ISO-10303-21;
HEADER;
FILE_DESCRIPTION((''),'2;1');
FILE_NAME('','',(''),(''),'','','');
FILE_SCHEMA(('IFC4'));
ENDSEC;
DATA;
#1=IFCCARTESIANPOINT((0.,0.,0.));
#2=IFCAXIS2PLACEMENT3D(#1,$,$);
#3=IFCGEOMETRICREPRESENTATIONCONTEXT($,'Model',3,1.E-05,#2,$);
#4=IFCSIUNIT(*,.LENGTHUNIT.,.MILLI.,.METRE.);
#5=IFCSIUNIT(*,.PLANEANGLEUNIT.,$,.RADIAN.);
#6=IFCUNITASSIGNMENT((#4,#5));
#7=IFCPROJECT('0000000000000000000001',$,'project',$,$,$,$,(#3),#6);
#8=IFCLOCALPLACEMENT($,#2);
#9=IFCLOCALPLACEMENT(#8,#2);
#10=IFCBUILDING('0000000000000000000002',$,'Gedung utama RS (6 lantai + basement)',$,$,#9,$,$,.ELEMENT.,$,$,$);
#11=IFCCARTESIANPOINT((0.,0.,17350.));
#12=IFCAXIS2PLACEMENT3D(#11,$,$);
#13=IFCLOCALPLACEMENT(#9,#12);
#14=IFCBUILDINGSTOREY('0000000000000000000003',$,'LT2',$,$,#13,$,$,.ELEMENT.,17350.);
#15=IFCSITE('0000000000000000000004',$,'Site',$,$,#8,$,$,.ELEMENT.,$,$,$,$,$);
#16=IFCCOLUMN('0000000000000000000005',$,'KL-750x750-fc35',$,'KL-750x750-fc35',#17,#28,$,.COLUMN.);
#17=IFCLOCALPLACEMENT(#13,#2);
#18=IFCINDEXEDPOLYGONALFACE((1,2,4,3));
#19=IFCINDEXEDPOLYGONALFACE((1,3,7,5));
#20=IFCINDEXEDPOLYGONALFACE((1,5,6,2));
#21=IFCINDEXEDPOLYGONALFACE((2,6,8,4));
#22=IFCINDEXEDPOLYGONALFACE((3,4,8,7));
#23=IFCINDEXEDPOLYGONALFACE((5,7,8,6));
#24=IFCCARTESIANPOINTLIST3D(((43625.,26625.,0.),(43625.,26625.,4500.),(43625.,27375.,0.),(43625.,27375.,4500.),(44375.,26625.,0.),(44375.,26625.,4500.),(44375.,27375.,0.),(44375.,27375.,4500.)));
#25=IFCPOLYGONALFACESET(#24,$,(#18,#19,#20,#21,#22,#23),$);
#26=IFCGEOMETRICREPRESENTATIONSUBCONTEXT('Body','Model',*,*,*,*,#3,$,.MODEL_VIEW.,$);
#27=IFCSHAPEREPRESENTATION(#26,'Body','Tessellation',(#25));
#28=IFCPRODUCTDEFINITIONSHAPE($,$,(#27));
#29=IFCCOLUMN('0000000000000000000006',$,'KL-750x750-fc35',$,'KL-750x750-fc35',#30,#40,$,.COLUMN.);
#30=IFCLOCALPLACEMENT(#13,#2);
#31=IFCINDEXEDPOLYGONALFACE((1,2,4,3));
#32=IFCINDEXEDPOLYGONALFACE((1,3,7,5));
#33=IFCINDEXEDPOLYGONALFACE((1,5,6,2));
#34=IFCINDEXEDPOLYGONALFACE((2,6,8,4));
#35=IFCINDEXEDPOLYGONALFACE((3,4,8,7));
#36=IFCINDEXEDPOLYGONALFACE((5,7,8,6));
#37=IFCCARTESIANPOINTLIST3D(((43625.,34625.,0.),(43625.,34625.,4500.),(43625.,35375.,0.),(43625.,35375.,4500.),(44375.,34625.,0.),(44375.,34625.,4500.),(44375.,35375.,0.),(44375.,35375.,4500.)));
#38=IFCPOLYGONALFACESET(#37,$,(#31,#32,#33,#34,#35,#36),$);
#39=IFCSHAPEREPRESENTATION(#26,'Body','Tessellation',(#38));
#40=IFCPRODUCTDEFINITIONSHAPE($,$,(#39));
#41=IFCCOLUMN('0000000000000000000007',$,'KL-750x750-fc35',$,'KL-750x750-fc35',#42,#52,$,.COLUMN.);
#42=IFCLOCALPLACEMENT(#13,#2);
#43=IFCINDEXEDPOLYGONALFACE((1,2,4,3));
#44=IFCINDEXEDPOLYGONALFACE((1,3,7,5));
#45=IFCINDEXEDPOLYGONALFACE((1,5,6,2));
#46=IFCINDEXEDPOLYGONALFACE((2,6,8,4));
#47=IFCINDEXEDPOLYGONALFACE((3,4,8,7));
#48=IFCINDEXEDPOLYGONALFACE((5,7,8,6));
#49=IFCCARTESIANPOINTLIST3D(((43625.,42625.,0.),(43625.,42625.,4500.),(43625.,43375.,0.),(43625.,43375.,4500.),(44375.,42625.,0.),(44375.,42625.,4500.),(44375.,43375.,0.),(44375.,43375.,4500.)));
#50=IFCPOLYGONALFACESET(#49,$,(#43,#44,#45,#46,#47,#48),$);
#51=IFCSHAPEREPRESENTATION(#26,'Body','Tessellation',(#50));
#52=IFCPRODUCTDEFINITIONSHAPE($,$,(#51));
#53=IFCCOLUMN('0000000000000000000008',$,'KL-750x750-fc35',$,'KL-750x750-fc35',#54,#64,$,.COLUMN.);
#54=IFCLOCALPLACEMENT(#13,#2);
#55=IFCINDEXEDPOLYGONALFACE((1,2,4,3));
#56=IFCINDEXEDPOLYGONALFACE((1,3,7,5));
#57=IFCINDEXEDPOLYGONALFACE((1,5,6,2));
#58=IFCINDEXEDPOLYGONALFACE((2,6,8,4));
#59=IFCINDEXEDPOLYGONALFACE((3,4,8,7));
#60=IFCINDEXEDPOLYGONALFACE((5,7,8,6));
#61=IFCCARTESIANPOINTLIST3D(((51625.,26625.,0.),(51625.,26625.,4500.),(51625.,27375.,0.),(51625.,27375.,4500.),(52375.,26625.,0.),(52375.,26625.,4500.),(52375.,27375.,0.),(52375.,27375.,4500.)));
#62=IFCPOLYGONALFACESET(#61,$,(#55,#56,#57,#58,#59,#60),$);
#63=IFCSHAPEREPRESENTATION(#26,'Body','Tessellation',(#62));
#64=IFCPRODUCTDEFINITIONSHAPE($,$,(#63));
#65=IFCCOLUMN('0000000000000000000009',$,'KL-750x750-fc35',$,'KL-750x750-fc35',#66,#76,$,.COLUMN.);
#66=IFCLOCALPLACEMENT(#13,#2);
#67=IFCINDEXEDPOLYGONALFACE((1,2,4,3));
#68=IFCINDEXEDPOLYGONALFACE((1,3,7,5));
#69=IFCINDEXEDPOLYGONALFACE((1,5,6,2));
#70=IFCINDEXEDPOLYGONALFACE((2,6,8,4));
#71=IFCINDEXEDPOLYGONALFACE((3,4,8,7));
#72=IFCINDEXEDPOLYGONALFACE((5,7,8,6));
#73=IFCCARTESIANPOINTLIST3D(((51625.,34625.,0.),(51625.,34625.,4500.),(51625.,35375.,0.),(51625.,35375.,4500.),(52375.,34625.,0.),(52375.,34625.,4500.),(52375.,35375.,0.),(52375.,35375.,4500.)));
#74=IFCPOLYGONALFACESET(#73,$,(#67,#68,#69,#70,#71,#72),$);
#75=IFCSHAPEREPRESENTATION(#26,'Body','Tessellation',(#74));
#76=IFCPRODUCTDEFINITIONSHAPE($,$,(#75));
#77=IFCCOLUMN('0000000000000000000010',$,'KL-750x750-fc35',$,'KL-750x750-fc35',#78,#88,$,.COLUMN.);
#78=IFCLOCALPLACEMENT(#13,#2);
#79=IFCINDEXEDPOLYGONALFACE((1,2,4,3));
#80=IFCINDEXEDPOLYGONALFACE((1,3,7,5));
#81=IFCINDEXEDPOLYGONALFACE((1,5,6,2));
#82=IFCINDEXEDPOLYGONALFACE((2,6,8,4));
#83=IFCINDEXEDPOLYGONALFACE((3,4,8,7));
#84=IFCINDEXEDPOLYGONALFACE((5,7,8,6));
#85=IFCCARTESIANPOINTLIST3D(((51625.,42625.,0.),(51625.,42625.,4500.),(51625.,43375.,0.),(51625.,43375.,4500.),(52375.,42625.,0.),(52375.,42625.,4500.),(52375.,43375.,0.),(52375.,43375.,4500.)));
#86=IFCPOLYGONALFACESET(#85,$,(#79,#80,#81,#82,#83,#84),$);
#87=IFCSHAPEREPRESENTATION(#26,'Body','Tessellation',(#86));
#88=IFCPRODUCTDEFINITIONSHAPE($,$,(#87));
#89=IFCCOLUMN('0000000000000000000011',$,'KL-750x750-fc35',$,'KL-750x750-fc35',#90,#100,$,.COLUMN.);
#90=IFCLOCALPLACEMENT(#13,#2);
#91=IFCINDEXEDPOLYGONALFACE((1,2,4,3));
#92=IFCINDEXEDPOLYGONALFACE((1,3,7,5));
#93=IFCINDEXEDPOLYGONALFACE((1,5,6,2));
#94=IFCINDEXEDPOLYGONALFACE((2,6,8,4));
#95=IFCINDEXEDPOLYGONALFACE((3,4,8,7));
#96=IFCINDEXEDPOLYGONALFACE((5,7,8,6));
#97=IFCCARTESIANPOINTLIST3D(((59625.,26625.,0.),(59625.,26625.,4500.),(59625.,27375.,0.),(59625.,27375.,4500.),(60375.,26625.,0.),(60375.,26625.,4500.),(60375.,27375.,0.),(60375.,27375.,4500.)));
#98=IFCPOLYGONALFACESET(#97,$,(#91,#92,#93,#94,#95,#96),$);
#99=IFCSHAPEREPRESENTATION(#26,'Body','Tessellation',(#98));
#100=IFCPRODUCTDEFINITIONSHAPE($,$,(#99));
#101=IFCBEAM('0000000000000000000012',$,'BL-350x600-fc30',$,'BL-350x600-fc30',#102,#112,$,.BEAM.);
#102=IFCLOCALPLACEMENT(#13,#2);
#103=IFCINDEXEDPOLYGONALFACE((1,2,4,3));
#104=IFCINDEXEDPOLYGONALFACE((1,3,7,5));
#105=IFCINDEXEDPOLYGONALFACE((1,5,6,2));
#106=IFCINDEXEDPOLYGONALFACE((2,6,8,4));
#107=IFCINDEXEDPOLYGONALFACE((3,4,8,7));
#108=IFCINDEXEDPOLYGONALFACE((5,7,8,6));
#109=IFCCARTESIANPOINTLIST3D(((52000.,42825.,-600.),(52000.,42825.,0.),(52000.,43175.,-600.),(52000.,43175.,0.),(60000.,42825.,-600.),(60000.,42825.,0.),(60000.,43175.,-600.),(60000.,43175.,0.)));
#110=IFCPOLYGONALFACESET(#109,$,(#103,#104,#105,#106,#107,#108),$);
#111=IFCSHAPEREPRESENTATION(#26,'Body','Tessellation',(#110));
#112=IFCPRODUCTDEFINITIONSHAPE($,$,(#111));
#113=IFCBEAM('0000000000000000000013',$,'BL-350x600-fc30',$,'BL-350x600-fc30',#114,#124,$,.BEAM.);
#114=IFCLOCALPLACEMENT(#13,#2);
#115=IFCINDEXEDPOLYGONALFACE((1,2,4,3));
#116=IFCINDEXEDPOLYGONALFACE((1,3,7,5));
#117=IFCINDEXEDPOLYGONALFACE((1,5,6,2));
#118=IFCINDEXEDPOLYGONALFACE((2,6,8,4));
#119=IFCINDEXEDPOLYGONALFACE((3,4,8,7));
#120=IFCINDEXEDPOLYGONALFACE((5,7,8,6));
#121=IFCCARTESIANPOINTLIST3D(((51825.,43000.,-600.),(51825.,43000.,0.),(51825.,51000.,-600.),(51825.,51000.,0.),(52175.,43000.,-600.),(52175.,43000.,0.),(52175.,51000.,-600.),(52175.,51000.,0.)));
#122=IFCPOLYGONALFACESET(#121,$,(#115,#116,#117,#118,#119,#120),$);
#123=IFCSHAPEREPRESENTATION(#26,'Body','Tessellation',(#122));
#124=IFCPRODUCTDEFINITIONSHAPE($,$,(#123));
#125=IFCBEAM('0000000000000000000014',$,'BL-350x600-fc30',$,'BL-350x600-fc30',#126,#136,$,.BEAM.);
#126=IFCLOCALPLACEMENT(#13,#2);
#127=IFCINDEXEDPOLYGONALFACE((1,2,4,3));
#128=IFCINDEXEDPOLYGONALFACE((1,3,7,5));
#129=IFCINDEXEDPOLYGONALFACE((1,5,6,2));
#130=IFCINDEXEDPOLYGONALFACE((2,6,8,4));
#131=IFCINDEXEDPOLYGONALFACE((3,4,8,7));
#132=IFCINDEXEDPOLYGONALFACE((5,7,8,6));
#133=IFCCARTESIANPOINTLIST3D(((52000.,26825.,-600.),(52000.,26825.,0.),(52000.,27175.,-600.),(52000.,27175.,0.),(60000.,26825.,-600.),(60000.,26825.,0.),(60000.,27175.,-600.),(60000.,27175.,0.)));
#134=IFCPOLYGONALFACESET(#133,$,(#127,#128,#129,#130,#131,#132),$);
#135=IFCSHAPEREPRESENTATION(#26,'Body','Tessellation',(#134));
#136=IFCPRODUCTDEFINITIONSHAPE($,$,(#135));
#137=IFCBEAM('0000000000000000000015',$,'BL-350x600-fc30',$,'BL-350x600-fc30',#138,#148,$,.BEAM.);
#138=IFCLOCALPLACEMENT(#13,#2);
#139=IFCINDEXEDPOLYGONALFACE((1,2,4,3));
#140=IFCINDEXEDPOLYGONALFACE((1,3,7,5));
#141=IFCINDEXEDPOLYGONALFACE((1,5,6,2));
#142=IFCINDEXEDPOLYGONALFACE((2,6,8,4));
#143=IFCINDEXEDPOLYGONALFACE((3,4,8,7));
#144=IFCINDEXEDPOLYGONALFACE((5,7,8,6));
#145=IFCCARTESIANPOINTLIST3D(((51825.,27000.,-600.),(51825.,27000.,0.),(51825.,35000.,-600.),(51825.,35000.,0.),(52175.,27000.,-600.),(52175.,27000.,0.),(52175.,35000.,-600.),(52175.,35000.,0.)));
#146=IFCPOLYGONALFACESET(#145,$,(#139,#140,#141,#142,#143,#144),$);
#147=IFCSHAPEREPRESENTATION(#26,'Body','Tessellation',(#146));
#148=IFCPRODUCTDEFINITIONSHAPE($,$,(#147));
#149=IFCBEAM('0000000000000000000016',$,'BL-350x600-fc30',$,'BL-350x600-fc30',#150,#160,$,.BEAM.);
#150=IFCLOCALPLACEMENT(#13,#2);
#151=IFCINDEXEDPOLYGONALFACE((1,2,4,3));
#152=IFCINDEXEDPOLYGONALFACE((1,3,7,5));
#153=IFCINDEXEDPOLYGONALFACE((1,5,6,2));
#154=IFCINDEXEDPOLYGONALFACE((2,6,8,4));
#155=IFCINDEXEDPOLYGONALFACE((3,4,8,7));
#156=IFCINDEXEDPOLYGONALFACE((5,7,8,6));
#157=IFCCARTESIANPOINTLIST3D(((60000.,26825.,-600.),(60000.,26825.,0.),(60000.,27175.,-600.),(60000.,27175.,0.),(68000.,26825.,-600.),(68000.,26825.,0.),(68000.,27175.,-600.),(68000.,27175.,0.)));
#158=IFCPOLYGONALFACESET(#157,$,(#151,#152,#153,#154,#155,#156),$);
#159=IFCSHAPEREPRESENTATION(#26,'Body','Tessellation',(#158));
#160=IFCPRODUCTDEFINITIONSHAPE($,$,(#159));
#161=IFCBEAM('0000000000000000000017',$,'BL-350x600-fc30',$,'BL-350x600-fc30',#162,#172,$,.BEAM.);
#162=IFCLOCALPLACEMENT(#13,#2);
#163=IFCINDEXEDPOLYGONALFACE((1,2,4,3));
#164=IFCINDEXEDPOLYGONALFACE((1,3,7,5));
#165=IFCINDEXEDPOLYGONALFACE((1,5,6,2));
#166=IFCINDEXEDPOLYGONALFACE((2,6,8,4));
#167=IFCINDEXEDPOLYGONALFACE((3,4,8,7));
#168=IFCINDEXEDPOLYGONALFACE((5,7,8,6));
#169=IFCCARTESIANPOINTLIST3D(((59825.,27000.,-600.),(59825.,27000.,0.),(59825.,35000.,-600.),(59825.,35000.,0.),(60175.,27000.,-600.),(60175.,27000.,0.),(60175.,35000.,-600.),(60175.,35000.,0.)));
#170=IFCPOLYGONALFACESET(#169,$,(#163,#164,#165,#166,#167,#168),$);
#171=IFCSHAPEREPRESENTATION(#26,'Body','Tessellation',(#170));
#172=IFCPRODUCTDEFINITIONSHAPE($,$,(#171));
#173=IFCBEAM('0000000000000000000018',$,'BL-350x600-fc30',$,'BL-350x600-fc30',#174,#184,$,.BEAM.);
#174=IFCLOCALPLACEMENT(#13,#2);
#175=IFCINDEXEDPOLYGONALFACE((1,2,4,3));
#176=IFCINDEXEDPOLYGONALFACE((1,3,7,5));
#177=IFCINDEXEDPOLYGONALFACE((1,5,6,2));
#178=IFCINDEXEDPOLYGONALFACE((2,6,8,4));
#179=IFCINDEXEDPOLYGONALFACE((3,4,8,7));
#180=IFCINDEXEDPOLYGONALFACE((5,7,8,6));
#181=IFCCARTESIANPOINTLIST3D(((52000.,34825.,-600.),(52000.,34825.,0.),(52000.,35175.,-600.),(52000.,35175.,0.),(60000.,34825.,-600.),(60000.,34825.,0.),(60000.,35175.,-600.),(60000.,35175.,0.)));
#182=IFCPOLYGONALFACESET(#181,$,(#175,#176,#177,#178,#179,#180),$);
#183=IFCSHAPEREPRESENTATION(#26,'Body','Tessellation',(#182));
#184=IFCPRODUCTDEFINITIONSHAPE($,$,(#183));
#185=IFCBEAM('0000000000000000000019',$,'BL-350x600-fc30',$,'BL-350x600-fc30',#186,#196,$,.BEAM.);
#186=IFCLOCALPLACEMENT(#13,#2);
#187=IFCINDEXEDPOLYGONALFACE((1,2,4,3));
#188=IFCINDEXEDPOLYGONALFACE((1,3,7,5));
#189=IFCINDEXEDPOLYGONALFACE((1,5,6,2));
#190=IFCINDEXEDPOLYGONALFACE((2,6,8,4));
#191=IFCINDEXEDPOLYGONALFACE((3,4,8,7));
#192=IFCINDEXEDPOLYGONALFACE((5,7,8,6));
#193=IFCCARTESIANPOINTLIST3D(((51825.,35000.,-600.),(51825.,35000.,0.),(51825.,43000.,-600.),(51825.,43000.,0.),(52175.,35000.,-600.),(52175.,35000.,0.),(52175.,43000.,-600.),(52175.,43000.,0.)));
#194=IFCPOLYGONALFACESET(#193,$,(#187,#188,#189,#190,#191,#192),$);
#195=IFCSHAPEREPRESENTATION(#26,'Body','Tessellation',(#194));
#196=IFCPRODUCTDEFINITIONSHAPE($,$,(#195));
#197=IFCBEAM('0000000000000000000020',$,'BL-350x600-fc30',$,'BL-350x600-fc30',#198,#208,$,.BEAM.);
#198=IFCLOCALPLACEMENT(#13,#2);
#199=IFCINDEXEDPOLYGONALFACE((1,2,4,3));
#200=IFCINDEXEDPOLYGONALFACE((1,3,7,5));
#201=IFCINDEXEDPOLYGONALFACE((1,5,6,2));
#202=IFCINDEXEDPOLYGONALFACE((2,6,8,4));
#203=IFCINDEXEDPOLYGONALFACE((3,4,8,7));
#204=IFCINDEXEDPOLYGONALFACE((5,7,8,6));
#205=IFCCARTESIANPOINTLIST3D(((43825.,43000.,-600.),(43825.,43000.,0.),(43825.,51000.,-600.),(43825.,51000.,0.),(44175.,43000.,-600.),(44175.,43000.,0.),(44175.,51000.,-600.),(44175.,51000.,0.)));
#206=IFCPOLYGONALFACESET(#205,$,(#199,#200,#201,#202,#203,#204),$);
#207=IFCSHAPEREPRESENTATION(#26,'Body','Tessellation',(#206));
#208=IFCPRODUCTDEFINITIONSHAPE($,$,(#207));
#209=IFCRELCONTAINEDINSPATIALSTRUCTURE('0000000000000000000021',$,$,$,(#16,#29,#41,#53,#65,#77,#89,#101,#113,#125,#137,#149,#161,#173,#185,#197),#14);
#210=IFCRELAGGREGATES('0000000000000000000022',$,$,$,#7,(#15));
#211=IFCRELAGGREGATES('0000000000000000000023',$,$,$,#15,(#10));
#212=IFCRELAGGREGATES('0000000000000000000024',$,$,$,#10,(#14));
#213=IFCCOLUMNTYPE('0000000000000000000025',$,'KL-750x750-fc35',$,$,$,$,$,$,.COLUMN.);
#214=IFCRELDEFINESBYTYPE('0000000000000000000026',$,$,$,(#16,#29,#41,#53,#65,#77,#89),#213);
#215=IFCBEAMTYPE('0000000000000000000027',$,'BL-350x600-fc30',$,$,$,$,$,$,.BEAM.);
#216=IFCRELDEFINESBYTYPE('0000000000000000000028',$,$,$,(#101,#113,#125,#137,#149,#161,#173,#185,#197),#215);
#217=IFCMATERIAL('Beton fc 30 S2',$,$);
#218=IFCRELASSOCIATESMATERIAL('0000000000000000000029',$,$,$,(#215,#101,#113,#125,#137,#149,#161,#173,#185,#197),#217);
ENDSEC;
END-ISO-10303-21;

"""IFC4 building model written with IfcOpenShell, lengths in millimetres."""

from ifc_helpers import new_model, si_unit, frame, origin, origin_2d, place, context, subcontext, project, spatial, rectangle, extrude, material, material_profile, profile_set, profile_usage, type_object, element, save


model = new_model("IFC4")

# Units and contexts
model_context = context("Model", 3, precision=1e-05, world=origin())
body_context = subcontext(model_context, "Body", "Model", "MODEL_VIEW")
ifc_project = project(units=[si_unit("LENGTHUNIT", "METRE", prefix="MILLI"), si_unit("PLANEANGLEUNIT", "RADIAN")], contexts=[model_context])

# Site, building, storey
site_placement = place(None, origin())
site = spatial("IfcSite", under=ifc_project, at=site_placement, Name="Site", CompositionType="ELEMENT")
building_placement = place(site_placement, origin())
building = spatial("IfcBuilding", under=site, at=building_placement, Name="Gedung utama RS (6 lantai + basement)", CompositionType="ELEMENT")
storey_placement = place(building_placement, frame((0.0, 0.0, 17350.0)))
storey = spatial("IfcBuildingStorey", under=building, at=storey_placement, Name="LT2", CompositionType="ELEMENT", Elevation=17350.0)

# Columns
ifc_material_profile_1 = material_profile(None, rectangle(XDim=750.0, YDim=750.0, at=origin_2d()), Name="KL-750x750-fc35")
ifc_profile_set_1 = profile_set([ifc_material_profile_1], Name="KL-750x750-fc35")
ifc_profile_usage_1 = profile_usage(ifc_profile_set_1, cardinal=5)
column_type = type_object("IfcColumnType", Name="KL-750x750-fc35", PredefinedType="COLUMN", material=ifc_profile_set_1)
for number, where, z_axis, x_axis, name in (
    (1, (44000.0, 27000.0, 0.0), (0.0, 0.0, 1.0), (1.0, 0.0, 0.0), "KL-750x750-fc35"),
    (2, (44000.0, 35000.0, 0.0), (0.0, 0.0, 1.0), (1.0, 0.0, 0.0), "KL-750x750-fc35"),
    (3, (44000.0, 43000.0, 0.0), (0.0, 0.0, 1.0), (1.0, 0.0, 0.0), "KL-750x750-fc35"),
    (4, (52000.0, 27000.0, 0.0), (0.0, 0.0, 1.0), (1.0, 0.0, 0.0), "KL-750x750-fc35"),
    (5, (52000.0, 35000.0, 0.0), (0.0, 0.0, 1.0), (1.0, 0.0, 0.0), "KL-750x750-fc35"),
    (6, (52000.0, 43000.0, 0.0), (0.0, 0.0, 1.0), (1.0, 0.0, 0.0), "KL-750x750-fc35"),
    (7, (60000.0, 27000.0, 0.0), (0.0, 0.0, 1.0), (1.0, 0.0, 0.0), "KL-750x750-fc35"),
):
    element("IfcColumn", number, at=place(storey_placement, frame(where, z_axis=z_axis, x_axis=x_axis)), inside=storey, type_object=column_type, material=ifc_profile_usage_1, Name=name, ObjectType="KL-750x750-fc35", PredefinedType="COLUMN", context=body_context, shape_type="SweptSolid", body=[
        extrude(rectangle(XDim=750.0, YDim=750.0, at=origin_2d()), origin(), (0.0, 0.0, 1.0), 4500.0),
    ])

# Beams
ifc_material_1 = material(Name="Beton fc 30 S2")
ifc_material_profile_2 = material_profile(ifc_material_1, rectangle(XDim=350.0, YDim=600.0, at=origin_2d()), Name="BL-350x600-fc30")
ifc_profile_set_2 = profile_set([ifc_material_profile_2], Name="BL-350x600-fc30")
ifc_profile_usage_2 = profile_usage(ifc_profile_set_2, cardinal=8)
beam_type = type_object("IfcBeamType", Name="BL-350x600-fc30", PredefinedType="BEAM", material=ifc_profile_set_2)
beam_1_placement = place(storey_placement, frame((52000.0, 43000.0, -300.0)))
element("IfcBeam", 8, at=beam_1_placement, inside=storey, type_object=beam_type, material=ifc_profile_usage_2, Name="BL-350x600-fc30", ObjectType="BL-350x600-fc30", PredefinedType="BEAM", context=body_context, shape_type="SweptSolid", body=[
    extrude(rectangle(XDim=350.0, YDim=600.0, at=origin_2d()), frame((0.0, 0.0, 0.0), z_axis=(1.0, 0.0, 0.0), x_axis=(0.0, 1.0, 0.0)), (0.0, 0.0, 1.0), 8000.0),
])
beam_2_placement = place(storey_placement, frame((52000.0, 43000.0, -300.0)))
element("IfcBeam", 9, at=beam_2_placement, inside=storey, type_object=beam_type, material=ifc_profile_usage_2, Name="BL-350x600-fc30", ObjectType="BL-350x600-fc30", PredefinedType="BEAM", context=body_context, shape_type="SweptSolid", body=[
    extrude(rectangle(XDim=350.0, YDim=600.0, at=origin_2d()), frame((0.0, 0.0, 0.0), z_axis=(0.0, 1.0, 0.0), x_axis=(-1.0, 0.0, 0.0)), (0.0, 0.0, 1.0), 8000.0),
])
beam_3_placement = place(storey_placement, frame((52000.0, 27000.0, -300.0)))
element("IfcBeam", 10, at=beam_3_placement, inside=storey, type_object=beam_type, material=ifc_profile_usage_2, Name="BL-350x600-fc30", ObjectType="BL-350x600-fc30", PredefinedType="BEAM", context=body_context, shape_type="SweptSolid", body=[
    extrude(rectangle(XDim=350.0, YDim=600.0, at=origin_2d()), frame((0.0, 0.0, 0.0), z_axis=(1.0, 0.0, 0.0), x_axis=(0.0, 1.0, 0.0)), (0.0, 0.0, 1.0), 8000.0),
])
beam_4_placement = place(storey_placement, frame((52000.0, 27000.0, -300.0)))
element("IfcBeam", 11, at=beam_4_placement, inside=storey, type_object=beam_type, material=ifc_profile_usage_2, Name="BL-350x600-fc30", ObjectType="BL-350x600-fc30", PredefinedType="BEAM", context=body_context, shape_type="SweptSolid", body=[
    extrude(rectangle(XDim=350.0, YDim=600.0, at=origin_2d()), frame((0.0, 0.0, 0.0), z_axis=(0.0, 1.0, 0.0), x_axis=(-1.0, 0.0, 0.0)), (0.0, 0.0, 1.0), 8000.0),
])
beam_5_placement = place(storey_placement, frame((60000.0, 27000.0, -300.0)))
element("IfcBeam", 12, at=beam_5_placement, inside=storey, type_object=beam_type, material=ifc_profile_usage_2, Name="BL-350x600-fc30", ObjectType="BL-350x600-fc30", PredefinedType="BEAM", context=body_context, shape_type="SweptSolid", body=[
    extrude(rectangle(XDim=350.0, YDim=600.0, at=origin_2d()), frame((0.0, 0.0, 0.0), z_axis=(1.0, 0.0, 0.0), x_axis=(0.0, 1.0, 0.0)), (0.0, 0.0, 1.0), 8000.0),
])
beam_6_placement = place(storey_placement, frame((60000.0, 27000.0, -300.0)))
element("IfcBeam", 13, at=beam_6_placement, inside=storey, type_object=beam_type, material=ifc_profile_usage_2, Name="BL-350x600-fc30", ObjectType="BL-350x600-fc30", PredefinedType="BEAM", context=body_context, shape_type="SweptSolid", body=[
    extrude(rectangle(XDim=350.0, YDim=600.0, at=origin_2d()), frame((0.0, 0.0, 0.0), z_axis=(0.0, 1.0, 0.0), x_axis=(-1.0, 0.0, 0.0)), (0.0, 0.0, 1.0), 8000.0),
])
beam_7_placement = place(storey_placement, frame((52000.0, 35000.0, -300.0)))
element("IfcBeam", 14, at=beam_7_placement, inside=storey, type_object=beam_type, material=ifc_profile_usage_2, Name="BL-350x600-fc30", ObjectType="BL-350x600-fc30", PredefinedType="BEAM", context=body_context, shape_type="SweptSolid", body=[
    extrude(rectangle(XDim=350.0, YDim=600.0, at=origin_2d()), frame((0.0, 0.0, 0.0), z_axis=(1.0, 0.0, 0.0), x_axis=(0.0, 1.0, 0.0)), (0.0, 0.0, 1.0), 8000.0),
])
for number, where, name in (
    (15, (52000.0, 35000.0, -300.0), "BL-350x600-fc30"),
    (16, (44000.0, 43000.0, -300.0), "BL-350x600-fc30"),
):
    element("IfcBeam", number, at=place(storey_placement, frame(where)), inside=storey, type_object=beam_type, material=ifc_profile_usage_2, Name=name, ObjectType="BL-350x600-fc30", PredefinedType="BEAM", context=body_context, shape_type="SweptSolid", body=[
        extrude(rectangle(XDim=350.0, YDim=600.0, at=origin_2d()), frame((0.0, 0.0, 0.0), z_axis=(0.0, 1.0, 0.0), x_axis=(-1.0, 0.0, 0.0)), (0.0, 0.0, 1.0), 8000.0),
    ])

save(model, "model.ifc")
